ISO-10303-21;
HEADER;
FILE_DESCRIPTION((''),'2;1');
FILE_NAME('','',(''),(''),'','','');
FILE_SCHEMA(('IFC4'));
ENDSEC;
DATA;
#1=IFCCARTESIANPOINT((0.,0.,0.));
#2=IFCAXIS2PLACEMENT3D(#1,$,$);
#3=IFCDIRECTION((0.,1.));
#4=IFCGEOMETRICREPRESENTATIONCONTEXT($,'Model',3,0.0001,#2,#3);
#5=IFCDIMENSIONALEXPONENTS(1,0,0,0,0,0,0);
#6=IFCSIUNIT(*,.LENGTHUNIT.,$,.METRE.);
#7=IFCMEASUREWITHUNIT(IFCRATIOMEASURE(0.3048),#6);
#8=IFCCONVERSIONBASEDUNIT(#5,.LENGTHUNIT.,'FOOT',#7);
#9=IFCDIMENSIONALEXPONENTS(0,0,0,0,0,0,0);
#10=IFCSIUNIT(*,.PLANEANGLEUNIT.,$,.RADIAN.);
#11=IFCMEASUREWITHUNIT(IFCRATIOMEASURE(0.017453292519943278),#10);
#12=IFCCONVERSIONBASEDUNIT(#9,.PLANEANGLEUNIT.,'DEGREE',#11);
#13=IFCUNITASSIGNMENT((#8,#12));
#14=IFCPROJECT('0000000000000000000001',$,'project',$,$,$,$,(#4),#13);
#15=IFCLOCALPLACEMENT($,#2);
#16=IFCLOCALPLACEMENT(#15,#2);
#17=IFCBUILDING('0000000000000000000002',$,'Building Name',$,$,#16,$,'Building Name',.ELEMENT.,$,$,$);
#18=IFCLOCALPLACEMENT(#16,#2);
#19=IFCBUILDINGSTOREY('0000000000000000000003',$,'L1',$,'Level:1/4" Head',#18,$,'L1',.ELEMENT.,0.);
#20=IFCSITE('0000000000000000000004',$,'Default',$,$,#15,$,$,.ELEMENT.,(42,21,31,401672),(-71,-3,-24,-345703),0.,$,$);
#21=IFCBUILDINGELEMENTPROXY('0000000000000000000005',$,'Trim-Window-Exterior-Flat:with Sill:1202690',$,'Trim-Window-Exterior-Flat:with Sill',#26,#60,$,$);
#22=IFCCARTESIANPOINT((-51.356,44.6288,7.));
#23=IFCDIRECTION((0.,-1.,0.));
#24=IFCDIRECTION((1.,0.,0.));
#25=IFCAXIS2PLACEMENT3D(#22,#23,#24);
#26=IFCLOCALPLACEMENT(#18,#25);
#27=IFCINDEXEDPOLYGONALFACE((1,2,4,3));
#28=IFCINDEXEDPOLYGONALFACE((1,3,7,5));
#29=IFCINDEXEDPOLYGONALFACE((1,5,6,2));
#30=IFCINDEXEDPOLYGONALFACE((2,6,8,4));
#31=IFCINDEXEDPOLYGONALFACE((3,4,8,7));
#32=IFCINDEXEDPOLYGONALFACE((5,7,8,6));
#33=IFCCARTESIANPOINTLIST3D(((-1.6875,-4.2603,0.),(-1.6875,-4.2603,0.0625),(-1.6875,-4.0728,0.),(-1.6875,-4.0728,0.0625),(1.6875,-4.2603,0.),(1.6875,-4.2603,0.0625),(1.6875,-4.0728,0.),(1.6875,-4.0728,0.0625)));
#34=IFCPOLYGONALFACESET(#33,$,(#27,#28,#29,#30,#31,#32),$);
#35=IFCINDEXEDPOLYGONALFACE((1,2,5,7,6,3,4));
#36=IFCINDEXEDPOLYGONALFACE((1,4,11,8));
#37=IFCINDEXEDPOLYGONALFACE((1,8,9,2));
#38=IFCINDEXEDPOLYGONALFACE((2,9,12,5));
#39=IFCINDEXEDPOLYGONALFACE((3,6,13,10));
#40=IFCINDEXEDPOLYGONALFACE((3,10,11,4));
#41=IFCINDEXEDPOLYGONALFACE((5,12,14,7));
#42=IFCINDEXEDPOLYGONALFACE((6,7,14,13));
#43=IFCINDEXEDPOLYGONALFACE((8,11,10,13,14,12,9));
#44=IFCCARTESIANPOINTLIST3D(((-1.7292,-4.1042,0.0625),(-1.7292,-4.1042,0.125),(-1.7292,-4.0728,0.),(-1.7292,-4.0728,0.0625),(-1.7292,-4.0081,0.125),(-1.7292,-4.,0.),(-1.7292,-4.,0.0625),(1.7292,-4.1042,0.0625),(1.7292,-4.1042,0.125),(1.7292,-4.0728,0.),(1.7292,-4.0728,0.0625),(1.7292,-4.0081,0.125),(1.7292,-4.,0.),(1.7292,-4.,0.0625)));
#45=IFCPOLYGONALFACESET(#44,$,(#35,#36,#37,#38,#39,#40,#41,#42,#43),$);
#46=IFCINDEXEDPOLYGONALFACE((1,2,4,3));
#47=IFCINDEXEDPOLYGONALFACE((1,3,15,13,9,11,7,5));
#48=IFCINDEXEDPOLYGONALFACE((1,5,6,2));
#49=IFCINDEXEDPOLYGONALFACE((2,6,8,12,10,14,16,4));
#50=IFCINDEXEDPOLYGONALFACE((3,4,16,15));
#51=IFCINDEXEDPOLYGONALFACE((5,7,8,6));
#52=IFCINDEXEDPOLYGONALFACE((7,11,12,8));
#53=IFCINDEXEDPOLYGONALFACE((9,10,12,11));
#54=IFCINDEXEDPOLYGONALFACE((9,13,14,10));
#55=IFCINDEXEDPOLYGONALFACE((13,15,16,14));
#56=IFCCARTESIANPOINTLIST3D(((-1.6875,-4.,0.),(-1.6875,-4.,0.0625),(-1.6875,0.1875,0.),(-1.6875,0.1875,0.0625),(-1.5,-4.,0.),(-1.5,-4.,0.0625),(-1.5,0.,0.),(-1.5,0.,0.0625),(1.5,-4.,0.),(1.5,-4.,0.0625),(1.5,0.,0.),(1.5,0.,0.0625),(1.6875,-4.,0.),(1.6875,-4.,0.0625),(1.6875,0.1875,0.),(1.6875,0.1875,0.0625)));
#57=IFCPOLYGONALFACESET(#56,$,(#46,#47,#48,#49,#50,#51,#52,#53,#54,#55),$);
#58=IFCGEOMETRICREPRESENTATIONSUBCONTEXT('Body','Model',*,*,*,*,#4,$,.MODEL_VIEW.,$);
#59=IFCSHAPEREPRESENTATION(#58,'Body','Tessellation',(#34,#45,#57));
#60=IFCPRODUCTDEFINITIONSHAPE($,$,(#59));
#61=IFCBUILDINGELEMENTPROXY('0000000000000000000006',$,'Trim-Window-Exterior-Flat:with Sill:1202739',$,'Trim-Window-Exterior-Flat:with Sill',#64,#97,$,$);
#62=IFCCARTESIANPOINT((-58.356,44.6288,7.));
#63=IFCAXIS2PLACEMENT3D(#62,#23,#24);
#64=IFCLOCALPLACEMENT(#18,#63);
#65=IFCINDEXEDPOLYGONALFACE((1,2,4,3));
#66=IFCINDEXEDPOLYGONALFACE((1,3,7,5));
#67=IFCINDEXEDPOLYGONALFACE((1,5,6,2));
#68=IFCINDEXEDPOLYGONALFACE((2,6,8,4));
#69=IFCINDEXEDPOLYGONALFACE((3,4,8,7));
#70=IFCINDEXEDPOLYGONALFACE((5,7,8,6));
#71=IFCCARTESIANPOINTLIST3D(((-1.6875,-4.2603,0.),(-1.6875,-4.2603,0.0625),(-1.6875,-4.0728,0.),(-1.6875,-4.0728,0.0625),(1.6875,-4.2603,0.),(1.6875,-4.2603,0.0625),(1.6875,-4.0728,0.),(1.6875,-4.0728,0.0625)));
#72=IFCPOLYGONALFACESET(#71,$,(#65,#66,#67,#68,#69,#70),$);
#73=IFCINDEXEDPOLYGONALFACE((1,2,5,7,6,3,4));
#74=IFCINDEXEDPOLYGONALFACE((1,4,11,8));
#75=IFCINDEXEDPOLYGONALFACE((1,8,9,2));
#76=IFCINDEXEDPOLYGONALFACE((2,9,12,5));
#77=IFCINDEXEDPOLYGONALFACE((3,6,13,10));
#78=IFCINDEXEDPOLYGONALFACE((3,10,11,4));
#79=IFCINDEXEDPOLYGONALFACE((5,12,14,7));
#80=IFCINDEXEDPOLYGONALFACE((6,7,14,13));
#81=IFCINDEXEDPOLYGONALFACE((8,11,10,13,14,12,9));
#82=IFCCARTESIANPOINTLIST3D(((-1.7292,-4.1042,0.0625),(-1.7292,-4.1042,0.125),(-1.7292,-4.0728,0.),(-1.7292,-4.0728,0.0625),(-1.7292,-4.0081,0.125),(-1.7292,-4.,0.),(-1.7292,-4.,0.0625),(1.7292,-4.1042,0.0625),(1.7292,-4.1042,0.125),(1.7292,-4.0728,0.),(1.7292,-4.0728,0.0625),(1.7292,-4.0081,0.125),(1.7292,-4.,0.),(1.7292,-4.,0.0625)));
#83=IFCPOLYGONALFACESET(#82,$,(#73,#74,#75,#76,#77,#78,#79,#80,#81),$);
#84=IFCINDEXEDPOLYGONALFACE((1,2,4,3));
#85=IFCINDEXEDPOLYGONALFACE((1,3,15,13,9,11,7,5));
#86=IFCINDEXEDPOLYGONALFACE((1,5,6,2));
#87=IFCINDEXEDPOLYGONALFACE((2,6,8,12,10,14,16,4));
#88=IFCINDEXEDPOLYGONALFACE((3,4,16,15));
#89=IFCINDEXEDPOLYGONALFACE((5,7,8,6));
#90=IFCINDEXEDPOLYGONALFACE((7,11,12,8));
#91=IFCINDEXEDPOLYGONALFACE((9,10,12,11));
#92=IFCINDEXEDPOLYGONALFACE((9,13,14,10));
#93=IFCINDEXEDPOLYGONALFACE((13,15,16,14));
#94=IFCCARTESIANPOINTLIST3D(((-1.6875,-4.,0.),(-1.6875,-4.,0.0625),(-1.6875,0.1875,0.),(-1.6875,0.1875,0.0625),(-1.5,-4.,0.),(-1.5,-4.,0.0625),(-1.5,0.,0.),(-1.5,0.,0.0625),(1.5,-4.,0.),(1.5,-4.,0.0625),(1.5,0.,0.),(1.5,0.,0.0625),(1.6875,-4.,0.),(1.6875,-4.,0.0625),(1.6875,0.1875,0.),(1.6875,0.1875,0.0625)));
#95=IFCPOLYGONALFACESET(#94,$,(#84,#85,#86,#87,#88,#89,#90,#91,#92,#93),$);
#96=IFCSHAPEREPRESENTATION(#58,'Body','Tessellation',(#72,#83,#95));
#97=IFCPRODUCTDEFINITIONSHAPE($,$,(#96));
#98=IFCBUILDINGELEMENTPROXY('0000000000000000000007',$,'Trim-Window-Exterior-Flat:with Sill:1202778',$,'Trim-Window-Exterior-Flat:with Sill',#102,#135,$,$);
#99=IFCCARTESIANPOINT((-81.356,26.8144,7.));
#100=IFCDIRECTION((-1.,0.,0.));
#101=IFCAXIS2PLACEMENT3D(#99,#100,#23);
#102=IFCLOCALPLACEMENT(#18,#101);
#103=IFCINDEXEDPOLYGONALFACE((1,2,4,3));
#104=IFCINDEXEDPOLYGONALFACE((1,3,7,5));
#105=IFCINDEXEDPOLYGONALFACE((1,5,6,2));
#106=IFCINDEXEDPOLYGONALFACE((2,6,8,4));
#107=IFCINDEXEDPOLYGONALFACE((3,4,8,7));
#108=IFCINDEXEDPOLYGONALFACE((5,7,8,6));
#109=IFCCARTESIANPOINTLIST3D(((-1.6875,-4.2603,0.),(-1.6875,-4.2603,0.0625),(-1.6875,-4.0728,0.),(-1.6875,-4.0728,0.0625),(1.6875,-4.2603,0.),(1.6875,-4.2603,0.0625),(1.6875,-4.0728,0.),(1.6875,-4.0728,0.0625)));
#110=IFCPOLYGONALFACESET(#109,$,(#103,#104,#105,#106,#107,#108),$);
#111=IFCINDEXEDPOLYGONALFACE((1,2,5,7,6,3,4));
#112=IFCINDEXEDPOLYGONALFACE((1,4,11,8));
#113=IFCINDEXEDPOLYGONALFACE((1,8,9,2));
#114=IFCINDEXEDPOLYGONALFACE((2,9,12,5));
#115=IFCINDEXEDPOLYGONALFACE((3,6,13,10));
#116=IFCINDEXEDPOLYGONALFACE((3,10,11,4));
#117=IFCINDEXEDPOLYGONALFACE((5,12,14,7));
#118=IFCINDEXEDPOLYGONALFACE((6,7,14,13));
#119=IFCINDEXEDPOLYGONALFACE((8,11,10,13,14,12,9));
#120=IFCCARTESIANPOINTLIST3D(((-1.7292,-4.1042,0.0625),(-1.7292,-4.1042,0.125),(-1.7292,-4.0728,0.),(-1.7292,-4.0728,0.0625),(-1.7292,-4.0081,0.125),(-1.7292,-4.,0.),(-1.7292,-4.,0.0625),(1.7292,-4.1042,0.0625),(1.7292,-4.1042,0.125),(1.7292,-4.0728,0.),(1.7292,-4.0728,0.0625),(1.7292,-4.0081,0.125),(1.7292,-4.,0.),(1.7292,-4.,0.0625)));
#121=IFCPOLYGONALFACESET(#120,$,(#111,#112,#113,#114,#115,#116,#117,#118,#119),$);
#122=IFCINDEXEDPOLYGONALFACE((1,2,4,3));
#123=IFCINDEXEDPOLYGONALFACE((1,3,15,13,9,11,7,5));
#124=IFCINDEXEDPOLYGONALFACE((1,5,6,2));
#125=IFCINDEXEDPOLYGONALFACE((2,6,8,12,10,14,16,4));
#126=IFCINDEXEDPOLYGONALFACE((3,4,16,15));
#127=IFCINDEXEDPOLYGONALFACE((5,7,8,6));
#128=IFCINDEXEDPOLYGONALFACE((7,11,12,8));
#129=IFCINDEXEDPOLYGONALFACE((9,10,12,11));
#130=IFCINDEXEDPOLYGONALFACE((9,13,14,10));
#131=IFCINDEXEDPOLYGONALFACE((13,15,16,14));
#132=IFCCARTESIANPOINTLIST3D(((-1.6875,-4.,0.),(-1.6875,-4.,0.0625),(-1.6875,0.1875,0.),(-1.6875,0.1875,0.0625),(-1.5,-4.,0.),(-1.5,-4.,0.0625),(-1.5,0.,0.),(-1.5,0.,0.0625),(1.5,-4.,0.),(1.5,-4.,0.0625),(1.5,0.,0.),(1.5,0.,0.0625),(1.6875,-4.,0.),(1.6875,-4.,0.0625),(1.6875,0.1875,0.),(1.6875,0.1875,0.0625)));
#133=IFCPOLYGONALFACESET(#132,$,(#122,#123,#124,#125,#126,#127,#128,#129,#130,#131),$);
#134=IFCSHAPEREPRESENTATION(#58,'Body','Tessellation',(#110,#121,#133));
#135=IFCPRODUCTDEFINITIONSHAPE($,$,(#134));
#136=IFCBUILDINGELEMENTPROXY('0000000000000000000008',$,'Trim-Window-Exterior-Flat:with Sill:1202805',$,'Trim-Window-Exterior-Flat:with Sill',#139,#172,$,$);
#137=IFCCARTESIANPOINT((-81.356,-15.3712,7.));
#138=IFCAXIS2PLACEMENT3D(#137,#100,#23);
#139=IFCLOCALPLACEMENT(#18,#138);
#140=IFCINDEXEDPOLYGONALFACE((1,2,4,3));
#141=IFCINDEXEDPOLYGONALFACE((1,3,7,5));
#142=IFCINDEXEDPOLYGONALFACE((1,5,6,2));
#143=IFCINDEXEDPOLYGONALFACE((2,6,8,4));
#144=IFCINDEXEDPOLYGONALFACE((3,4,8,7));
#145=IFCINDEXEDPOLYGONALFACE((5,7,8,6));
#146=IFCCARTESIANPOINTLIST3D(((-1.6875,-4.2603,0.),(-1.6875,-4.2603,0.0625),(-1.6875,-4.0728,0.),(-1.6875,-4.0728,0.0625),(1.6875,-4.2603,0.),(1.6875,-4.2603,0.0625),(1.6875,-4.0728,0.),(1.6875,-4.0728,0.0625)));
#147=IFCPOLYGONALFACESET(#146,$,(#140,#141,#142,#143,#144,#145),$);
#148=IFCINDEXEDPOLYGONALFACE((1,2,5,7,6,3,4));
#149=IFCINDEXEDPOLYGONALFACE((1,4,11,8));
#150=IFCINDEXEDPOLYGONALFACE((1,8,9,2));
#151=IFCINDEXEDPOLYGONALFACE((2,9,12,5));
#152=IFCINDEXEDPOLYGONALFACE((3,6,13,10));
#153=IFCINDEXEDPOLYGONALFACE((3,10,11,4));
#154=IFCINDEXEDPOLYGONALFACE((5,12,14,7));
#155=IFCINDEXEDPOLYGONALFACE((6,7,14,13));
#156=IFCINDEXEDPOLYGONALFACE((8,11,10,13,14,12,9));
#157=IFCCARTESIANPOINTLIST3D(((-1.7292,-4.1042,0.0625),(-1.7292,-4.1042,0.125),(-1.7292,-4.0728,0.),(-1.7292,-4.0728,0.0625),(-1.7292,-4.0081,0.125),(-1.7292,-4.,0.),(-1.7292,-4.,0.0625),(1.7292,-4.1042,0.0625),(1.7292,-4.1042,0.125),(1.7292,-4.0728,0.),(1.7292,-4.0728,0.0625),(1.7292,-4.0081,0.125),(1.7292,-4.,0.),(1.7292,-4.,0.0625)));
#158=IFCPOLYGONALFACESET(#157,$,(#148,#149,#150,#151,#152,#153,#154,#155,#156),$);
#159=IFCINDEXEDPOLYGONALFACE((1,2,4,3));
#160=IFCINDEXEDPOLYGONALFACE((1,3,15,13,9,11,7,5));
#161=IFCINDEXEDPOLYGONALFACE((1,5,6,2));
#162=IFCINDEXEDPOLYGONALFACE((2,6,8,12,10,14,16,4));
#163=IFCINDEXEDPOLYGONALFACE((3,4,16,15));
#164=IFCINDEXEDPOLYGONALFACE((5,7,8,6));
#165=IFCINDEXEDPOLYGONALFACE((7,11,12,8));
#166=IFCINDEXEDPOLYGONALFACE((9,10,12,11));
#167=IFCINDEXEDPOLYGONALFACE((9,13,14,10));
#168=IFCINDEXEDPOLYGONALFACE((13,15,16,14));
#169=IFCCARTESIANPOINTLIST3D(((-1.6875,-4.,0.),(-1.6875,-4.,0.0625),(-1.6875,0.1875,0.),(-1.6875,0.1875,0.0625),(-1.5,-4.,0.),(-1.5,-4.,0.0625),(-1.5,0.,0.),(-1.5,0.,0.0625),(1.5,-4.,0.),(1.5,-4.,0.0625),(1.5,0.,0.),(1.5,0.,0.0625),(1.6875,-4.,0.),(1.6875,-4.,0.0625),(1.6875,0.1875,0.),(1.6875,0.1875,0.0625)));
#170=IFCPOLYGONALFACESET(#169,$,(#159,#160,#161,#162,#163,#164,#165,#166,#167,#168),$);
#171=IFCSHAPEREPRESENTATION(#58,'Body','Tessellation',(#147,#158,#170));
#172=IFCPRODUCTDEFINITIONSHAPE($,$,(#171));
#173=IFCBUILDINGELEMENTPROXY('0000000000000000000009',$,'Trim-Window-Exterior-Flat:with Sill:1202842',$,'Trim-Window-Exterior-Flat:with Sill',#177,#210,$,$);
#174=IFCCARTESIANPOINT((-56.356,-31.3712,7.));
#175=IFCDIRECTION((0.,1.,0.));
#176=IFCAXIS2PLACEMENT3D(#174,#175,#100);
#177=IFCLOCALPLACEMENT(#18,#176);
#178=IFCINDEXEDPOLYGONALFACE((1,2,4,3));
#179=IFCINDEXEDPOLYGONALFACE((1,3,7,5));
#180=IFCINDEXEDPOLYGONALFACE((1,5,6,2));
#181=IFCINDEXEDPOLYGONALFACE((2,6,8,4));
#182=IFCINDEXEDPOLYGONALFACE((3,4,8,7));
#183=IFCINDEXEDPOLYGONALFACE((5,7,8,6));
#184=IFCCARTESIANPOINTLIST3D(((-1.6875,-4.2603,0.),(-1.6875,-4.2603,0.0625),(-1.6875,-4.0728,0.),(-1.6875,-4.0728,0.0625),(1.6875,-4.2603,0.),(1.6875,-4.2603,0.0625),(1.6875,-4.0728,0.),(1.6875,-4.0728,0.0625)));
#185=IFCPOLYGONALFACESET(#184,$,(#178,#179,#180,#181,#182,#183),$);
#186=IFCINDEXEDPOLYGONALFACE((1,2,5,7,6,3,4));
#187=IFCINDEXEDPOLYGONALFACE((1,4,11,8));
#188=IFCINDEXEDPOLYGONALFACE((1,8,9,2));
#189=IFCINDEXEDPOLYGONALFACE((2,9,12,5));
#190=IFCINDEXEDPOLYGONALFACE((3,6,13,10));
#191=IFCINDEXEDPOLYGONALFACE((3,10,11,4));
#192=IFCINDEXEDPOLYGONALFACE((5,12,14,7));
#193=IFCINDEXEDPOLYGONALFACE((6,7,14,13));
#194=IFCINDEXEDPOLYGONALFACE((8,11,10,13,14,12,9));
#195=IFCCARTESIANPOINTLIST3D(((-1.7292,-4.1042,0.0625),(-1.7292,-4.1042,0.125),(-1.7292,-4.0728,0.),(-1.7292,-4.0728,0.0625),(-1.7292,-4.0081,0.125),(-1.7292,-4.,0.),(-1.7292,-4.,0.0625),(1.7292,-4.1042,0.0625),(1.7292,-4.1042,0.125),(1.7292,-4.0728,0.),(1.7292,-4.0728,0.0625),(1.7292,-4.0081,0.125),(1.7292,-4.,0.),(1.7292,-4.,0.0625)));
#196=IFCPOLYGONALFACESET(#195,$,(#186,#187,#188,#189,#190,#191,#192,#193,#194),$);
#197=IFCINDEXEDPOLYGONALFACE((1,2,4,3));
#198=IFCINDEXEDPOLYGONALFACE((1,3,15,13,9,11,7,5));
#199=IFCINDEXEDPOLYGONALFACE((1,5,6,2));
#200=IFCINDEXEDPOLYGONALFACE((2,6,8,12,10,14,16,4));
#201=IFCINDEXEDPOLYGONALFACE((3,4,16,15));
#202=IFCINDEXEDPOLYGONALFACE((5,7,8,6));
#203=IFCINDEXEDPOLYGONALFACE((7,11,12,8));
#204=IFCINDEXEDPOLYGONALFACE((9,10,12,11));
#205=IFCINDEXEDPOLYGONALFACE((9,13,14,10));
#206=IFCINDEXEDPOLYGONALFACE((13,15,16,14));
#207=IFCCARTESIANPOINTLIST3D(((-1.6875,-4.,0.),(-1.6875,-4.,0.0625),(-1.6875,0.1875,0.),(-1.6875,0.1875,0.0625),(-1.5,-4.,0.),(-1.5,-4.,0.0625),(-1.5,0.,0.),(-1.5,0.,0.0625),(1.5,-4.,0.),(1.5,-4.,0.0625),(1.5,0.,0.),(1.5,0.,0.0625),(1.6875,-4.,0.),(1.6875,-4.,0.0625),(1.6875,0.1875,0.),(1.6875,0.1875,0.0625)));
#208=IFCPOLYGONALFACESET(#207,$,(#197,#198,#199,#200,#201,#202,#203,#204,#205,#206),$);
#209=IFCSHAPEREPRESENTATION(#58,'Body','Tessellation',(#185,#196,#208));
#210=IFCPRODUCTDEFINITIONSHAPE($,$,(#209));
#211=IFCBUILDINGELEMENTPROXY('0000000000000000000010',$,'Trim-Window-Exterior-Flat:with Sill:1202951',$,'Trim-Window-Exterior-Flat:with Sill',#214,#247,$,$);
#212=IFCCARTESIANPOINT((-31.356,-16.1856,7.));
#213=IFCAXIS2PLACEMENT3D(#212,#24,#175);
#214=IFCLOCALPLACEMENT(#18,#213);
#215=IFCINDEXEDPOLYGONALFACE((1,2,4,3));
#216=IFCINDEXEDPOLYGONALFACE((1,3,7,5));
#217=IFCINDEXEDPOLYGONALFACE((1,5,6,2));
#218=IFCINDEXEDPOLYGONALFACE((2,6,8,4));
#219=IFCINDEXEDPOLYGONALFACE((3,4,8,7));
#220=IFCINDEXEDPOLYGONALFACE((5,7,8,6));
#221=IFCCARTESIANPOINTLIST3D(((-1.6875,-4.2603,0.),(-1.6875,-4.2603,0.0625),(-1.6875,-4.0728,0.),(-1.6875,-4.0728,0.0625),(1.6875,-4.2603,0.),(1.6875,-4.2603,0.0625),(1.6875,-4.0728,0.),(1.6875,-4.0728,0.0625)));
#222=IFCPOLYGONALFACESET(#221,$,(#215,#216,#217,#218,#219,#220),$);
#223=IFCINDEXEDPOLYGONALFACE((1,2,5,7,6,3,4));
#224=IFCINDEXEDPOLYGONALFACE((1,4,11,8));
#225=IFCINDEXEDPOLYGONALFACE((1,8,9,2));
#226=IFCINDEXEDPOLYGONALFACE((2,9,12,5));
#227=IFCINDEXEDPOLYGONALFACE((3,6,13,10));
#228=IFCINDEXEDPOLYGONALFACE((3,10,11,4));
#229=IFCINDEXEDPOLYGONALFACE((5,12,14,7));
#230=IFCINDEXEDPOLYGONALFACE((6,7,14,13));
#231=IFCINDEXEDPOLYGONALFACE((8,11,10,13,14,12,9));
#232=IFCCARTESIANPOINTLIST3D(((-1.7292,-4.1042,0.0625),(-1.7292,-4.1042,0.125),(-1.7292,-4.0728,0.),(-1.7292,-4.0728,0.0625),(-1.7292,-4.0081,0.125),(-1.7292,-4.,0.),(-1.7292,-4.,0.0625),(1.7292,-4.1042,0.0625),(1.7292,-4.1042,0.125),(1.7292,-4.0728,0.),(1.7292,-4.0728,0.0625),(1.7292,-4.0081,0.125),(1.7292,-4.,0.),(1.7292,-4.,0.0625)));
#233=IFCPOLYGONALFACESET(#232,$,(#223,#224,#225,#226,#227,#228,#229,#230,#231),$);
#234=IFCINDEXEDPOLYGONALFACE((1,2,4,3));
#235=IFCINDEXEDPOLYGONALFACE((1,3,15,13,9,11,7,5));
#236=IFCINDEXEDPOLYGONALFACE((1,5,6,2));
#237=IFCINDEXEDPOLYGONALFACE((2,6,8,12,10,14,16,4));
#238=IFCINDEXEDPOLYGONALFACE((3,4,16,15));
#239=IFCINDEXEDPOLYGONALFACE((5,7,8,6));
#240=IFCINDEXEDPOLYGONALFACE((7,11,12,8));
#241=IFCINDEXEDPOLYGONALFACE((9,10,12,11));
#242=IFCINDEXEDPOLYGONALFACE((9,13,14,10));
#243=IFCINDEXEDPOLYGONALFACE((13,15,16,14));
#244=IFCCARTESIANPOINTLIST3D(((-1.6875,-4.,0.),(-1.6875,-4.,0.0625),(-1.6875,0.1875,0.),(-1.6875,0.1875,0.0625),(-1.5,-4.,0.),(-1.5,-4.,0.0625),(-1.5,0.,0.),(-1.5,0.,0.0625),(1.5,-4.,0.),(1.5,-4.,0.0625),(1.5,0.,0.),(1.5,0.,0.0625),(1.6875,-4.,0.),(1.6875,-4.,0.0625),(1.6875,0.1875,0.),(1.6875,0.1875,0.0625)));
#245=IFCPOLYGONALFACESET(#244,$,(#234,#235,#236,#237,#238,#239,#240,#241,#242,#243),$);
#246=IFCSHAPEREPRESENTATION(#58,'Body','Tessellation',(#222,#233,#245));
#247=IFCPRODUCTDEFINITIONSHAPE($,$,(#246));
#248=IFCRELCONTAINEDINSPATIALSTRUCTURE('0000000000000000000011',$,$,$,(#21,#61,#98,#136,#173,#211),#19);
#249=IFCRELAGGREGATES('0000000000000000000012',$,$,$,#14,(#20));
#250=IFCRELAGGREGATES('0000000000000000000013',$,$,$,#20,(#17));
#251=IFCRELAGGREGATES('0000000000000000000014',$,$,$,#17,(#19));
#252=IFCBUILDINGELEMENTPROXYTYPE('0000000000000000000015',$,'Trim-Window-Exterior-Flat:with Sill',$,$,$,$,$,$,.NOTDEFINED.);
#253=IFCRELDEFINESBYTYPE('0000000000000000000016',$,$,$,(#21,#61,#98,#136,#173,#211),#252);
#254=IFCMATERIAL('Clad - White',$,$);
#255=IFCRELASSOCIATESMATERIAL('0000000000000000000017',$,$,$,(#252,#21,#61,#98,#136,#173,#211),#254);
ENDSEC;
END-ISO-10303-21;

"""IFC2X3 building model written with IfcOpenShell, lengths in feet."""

from ifc_helpers import new_model, entity, si_unit, converted_unit, direction, frame, frame_2d, origin, place, context, subcontext, project, spatial, polyline, rectangle, outline, extrude, source, transform, mapped, material, type_object, type_shapes, element, save


model = new_model("IFC2X3")

# Units and contexts
model_context = context("Model", 3, precision=0.0001, world=origin(), true_north=direction((0.0, 1.0)))
body_context = subcontext(model_context, "Body", "Model", "MODEL_VIEW")
ifc_project = project(units=[converted_unit("LENGTHUNIT", "FOOT", entity("IfcRatioMeasure", 0.3048), si_unit("LENGTHUNIT", "METRE"), dimensions=[1, 0, 0, 0, 0, 0, 0]), converted_unit("PLANEANGLEUNIT", "DEGREE", entity("IfcRatioMeasure", 0.017453292519943278), si_unit("PLANEANGLEUNIT", "RADIAN"), dimensions=[0, 0, 0, 0, 0, 0, 0])], contexts=[model_context])

# Site, building, storey
site_placement = place(None, origin())
site = spatial("IfcSite", under=ifc_project, at=site_placement, Name="Default", CompositionType="ELEMENT", RefLatitude=(42, 21, 31, 401672), RefLongitude=(-71, -3, -24, -345703), RefElevation=0.0)
building_placement = place(site_placement, origin())
building = spatial("IfcBuilding", under=site, at=building_placement, Name="Building Name", LongName="Building Name", CompositionType="ELEMENT")
storey_placement = place(building_placement, origin())
storey = spatial("IfcBuildingStorey", under=building, at=storey_placement, Name="L1", ObjectType="Level:1/4\" Head", LongName="L1", CompositionType="ELEMENT", Elevation=0.0)

# Building element proxies
ifc_material_1 = material(Name="Clad - White")
building_element_proxy_type_1 = type_object("IfcBuildingElementProxyType", Name="Trim-Window-Exterior-Flat:with Sill", PredefinedType="NOTDEFINED", material=ifc_material_1)
shared_shape_1 = source(origin(), body_context, "Body", "SweptSolid", [
    extrude(rectangle(XDim=3.375, YDim=0.1875, at=frame_2d((0.0, 0.0), x_axis=(1.0, 0.0))), frame((0.0, -4.1665, 0.0), z_axis=(0.0, 0.0, 1.0), x_axis=(-1.0, 0.0, 0.0)), (0.0, 0.0, 1.0), 0.0625),
    extrude(outline(polyline([(-0.0625, -0.0525), (0.0, -0.0525), (0.0, -0.0211), (0.0625, -0.0211), (0.0625, 0.0517), (0.0, 0.0517), (-0.0625, 0.0436), (-0.0625, -0.0525)])), frame((-1.7292, -4.0517, 0.0625), z_axis=(1.0, 0.0, 0.0), x_axis=(0.0, 0.0, -1.0)), (0.0, 0.0, 1.0), 3.4583),
    extrude(outline(polyline([(-2.1406, -1.6875), (2.0469, -1.6875), (2.0469, -1.5), (-1.9531, -1.5), (-1.9531, 1.5), (2.0469, 1.5), (2.0469, 1.6875), (-2.1406, 1.6875), (-2.1406, -1.6875)])), frame((0.0, -1.9531, 0.0), z_axis=(0.0, 0.0, 1.0), x_axis=(0.0, -1.0, 0.0)), (0.0, 0.0, 1.0), 0.0625),
])
type_shapes(building_element_proxy_type_1, [shared_shape_1])
for number, where, z_axis, x_axis, name in (
    (1, (-51.356, 44.6288, 7.0), (0.0, -1.0, 0.0), (1.0, 0.0, 0.0), "Trim-Window-Exterior-Flat:with Sill:1202690"),
    (2, (-58.356, 44.6288, 7.0), (0.0, -1.0, 0.0), (1.0, 0.0, 0.0), "Trim-Window-Exterior-Flat:with Sill:1202739"),
    (3, (-81.356, 26.8144, 7.0), (-1.0, 0.0, 0.0), (0.0, -1.0, 0.0), "Trim-Window-Exterior-Flat:with Sill:1202778"),
    (4, (-81.356, -15.3712, 7.0), (-1.0, 0.0, 0.0), (0.0, -1.0, 0.0), "Trim-Window-Exterior-Flat:with Sill:1202805"),
    (5, (-56.356, -31.3712, 7.0), (0.0, 1.0, 0.0), (-1.0, 0.0, 0.0), "Trim-Window-Exterior-Flat:with Sill:1202842"),
    (6, (-31.356, -16.1856, 7.0), (1.0, 0.0, 0.0), (0.0, 1.0, 0.0), "Trim-Window-Exterior-Flat:with Sill:1202951"),
):
    element("IfcBuildingElementProxy", number, at=place(storey_placement, frame(where, z_axis=z_axis, x_axis=x_axis)), inside=storey, type_object=building_element_proxy_type_1, material=ifc_material_1, Name=name, ObjectType="Trim-Window-Exterior-Flat:with Sill", context=body_context, shape_type="MappedRepresentation", body=[
        mapped(shared_shape_1, transform((0.0, 0.0, 0.0), scale=1.0)),
    ])

save(model, "model.ifc")
